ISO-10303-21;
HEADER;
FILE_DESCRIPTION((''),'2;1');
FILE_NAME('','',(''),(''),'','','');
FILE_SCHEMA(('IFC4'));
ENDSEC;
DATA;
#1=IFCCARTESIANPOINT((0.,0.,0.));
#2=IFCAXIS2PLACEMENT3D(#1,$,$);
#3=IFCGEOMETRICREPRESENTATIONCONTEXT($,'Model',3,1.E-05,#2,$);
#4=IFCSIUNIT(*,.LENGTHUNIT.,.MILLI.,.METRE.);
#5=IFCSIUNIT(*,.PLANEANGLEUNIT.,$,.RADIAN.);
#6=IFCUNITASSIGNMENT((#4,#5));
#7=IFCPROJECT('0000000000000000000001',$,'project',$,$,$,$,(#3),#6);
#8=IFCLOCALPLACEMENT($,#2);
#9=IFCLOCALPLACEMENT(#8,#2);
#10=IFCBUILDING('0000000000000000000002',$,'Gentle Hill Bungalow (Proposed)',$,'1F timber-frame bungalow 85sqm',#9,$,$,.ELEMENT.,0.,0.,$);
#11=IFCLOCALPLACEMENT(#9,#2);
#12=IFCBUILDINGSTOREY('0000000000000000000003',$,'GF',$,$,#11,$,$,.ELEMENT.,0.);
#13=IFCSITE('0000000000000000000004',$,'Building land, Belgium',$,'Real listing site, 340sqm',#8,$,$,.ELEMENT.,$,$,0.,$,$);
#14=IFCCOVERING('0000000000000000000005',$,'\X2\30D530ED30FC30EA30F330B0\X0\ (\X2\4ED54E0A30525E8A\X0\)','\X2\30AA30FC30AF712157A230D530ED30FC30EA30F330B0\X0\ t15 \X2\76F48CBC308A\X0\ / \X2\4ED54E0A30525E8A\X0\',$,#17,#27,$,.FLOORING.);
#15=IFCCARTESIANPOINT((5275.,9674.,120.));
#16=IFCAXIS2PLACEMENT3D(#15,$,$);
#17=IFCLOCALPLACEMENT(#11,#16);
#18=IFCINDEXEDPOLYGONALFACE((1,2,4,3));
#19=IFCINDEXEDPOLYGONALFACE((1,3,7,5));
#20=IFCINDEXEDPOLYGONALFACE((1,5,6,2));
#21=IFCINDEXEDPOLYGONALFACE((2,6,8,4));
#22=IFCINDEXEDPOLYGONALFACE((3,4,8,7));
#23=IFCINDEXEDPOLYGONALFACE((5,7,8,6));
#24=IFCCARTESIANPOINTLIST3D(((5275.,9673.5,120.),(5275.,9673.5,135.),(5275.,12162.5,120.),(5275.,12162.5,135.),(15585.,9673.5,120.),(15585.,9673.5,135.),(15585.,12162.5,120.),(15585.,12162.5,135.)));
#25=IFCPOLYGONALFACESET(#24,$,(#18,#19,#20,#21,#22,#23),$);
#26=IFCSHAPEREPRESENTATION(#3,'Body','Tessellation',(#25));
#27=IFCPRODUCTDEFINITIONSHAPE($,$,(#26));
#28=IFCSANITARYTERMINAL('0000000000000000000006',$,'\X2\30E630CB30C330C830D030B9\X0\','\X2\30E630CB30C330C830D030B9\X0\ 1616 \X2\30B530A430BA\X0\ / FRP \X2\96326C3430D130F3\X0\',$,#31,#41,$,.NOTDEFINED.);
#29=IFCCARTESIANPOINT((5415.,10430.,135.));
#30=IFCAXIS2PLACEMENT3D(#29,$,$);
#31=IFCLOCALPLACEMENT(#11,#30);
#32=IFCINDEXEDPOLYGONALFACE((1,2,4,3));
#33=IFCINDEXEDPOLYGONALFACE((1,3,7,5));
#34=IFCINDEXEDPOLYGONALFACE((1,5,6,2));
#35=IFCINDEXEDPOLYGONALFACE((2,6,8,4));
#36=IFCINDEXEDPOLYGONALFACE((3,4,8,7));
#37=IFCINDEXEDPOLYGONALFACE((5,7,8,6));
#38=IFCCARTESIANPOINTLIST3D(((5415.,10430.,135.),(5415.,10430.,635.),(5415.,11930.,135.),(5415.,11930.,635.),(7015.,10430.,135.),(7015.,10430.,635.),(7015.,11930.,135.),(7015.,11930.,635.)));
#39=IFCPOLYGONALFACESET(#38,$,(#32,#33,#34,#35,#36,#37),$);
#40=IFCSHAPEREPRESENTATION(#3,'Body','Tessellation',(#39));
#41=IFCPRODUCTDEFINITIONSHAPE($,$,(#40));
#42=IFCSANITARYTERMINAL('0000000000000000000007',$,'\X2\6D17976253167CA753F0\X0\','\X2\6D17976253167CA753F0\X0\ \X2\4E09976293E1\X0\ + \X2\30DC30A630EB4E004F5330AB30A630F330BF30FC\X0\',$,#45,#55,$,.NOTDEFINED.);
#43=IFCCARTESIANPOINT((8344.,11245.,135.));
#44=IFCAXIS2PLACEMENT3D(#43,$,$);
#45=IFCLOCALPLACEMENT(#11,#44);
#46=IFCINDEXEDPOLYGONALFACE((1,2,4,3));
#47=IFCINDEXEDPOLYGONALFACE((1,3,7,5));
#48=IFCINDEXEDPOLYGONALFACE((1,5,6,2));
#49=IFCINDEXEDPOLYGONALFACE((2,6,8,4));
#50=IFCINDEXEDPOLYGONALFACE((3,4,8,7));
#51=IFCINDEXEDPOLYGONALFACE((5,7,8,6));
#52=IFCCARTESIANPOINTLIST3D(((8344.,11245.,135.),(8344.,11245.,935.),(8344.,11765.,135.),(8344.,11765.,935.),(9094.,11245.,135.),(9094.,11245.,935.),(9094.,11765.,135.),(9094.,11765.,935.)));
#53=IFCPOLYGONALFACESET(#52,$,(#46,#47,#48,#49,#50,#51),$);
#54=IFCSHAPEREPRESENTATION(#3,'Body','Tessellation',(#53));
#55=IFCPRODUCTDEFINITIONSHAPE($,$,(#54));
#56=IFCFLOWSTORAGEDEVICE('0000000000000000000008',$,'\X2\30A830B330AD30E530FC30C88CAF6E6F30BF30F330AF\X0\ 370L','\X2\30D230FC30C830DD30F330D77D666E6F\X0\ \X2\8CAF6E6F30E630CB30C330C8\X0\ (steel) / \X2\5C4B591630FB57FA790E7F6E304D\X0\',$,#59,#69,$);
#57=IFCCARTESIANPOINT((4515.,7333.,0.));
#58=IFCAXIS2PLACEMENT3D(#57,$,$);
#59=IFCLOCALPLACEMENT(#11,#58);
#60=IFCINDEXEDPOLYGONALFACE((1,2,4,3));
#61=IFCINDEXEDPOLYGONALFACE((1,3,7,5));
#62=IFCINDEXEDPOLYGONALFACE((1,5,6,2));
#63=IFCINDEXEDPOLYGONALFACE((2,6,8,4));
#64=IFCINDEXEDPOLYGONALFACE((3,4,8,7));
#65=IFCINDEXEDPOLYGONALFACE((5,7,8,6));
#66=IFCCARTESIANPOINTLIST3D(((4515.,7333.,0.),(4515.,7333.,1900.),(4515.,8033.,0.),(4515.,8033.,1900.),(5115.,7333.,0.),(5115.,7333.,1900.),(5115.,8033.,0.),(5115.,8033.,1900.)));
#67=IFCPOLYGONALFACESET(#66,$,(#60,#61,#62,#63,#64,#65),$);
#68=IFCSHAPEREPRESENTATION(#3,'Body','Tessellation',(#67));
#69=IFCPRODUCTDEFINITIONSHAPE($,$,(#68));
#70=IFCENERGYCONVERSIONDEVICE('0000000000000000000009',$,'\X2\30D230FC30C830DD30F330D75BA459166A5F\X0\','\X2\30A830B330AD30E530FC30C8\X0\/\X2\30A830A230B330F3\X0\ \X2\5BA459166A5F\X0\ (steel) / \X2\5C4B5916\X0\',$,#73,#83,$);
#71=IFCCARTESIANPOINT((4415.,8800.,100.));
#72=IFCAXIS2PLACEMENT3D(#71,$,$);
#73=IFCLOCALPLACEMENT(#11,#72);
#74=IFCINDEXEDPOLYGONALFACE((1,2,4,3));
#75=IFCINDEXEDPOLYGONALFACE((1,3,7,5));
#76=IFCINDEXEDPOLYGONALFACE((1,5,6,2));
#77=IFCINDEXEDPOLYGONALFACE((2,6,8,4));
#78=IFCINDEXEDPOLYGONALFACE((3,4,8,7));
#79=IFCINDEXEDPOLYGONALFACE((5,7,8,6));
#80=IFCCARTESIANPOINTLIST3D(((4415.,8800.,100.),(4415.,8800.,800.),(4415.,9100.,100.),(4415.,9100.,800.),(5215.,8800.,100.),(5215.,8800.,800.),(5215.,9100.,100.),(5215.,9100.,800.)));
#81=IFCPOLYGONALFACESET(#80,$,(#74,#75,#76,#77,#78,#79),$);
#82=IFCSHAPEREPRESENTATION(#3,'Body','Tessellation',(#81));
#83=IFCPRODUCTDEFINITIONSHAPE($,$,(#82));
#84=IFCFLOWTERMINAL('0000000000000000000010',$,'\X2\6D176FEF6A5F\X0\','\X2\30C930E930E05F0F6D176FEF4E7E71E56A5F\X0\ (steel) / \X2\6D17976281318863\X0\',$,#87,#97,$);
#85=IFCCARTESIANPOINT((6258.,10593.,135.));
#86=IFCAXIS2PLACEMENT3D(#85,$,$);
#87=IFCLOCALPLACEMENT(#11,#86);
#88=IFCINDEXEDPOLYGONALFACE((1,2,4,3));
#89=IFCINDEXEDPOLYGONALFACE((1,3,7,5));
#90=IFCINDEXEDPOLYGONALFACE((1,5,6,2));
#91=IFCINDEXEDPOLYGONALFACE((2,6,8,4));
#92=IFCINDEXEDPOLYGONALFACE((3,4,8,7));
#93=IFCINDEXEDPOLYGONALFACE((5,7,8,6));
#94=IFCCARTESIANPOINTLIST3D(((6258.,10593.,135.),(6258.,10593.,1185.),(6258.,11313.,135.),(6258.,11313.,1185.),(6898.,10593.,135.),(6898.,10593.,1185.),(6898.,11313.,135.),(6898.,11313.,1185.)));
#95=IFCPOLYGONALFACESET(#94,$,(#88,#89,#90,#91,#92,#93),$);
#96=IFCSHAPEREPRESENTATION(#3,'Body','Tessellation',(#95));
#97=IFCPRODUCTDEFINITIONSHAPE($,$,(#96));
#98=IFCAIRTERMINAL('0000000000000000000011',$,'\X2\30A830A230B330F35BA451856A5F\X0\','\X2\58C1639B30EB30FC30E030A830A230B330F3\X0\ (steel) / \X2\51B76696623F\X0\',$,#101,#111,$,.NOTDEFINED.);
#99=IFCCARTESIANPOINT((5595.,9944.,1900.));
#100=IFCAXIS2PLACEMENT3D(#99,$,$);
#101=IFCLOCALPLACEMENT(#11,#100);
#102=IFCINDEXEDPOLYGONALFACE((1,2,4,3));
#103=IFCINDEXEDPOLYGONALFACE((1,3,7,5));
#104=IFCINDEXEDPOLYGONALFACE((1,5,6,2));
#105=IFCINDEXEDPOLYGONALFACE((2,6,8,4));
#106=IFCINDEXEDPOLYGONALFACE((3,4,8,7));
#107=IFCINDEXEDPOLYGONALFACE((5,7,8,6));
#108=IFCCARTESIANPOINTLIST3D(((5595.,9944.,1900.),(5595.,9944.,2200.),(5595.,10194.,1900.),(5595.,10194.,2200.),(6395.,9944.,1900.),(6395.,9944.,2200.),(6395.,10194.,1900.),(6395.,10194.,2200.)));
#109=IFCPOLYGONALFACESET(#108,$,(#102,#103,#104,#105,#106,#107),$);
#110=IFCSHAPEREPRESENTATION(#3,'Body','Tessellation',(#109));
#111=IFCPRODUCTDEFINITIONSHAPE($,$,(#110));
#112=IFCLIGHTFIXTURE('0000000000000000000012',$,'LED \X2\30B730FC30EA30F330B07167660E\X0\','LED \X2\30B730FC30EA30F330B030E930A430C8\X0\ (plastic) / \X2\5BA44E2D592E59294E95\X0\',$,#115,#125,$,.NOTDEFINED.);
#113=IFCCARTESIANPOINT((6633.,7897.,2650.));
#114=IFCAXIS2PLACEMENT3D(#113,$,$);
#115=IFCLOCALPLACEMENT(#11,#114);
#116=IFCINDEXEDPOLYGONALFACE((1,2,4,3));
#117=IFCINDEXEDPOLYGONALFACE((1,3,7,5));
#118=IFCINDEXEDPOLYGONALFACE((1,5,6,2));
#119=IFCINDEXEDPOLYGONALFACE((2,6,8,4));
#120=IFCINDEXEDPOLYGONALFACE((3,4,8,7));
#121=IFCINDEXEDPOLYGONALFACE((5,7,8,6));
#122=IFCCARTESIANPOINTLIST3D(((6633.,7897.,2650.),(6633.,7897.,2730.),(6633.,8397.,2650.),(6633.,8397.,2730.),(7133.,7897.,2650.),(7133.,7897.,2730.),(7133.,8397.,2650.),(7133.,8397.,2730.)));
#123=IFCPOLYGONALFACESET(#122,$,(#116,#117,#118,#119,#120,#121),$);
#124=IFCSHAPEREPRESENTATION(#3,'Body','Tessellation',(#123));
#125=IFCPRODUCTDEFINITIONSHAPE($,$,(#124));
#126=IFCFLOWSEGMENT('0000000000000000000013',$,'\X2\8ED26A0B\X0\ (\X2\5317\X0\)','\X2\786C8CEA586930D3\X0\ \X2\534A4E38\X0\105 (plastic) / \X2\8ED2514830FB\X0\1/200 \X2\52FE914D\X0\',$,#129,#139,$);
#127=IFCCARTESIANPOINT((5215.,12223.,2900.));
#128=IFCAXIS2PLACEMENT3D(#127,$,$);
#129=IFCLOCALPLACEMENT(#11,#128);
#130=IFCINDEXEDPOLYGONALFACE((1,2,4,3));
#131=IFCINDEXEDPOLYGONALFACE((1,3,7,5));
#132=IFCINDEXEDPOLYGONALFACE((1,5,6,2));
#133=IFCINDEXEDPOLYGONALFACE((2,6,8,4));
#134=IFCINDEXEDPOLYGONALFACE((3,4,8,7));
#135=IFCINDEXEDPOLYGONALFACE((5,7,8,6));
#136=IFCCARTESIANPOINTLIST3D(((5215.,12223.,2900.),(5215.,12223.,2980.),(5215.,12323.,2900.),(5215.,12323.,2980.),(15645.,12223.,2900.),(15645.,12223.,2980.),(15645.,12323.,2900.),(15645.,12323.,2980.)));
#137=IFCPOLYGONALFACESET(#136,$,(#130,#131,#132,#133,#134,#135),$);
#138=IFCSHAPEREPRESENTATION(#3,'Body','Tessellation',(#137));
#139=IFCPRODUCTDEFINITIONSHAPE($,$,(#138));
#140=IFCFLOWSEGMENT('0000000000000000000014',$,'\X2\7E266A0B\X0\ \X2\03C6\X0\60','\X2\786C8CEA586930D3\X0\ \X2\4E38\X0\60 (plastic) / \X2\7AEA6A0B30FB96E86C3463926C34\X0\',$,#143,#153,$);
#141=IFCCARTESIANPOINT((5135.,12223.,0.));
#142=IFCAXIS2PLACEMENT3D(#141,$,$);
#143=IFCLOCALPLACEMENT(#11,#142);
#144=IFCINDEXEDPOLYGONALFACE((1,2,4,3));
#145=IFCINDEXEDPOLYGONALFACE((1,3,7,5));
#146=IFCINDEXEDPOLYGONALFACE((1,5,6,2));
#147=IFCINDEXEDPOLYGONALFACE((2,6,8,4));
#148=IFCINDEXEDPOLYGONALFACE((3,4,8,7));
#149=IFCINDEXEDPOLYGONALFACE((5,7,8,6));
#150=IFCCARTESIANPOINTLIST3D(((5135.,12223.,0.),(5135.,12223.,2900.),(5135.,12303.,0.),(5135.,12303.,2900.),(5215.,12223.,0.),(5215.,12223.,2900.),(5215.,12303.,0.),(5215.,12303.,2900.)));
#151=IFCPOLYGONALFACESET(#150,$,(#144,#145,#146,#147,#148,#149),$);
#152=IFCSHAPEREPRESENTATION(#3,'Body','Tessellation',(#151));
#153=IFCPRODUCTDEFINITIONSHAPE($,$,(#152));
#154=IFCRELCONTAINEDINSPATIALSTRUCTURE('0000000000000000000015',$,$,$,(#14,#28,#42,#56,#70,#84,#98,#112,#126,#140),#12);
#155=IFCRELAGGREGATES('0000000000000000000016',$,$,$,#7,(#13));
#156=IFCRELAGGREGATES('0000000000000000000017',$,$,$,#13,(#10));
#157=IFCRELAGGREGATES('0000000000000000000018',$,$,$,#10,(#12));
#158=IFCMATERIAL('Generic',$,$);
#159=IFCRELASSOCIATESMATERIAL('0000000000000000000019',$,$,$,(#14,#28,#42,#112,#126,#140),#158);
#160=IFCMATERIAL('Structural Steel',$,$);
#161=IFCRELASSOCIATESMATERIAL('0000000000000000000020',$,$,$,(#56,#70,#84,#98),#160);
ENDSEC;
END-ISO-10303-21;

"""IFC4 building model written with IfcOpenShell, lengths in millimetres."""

from ifc_helpers import new_model, si_unit, frame, frame_2d, origin, place, context, project, spatial, rectangle, extrude, material, element, save


model = new_model("IFC4")

# Units and contexts
model_context = context("Model", 3, precision=1e-05, world=origin())
ifc_project = project(units=[si_unit("LENGTHUNIT", "METRE", prefix="MILLI"), si_unit("PLANEANGLEUNIT", "RADIAN")], contexts=[model_context])

# Site, building, storey
site_placement = place(None, origin())
site = spatial("IfcSite", under=ifc_project, at=site_placement, Name="Building land, Belgium", ObjectType="Real listing site, 340sqm", CompositionType="ELEMENT", RefElevation=0.0)
building_placement = place(site_placement, origin())
building = spatial("IfcBuilding", under=site, at=building_placement, Name="Gentle Hill Bungalow (Proposed)", ObjectType="1F timber-frame bungalow 85sqm", CompositionType="ELEMENT", ElevationOfRefHeight=0.0, ElevationOfTerrain=0.0)
storey_placement = place(building_placement, origin())
storey = spatial("IfcBuildingStorey", under=building, at=storey_placement, Name="GF", CompositionType="ELEMENT", Elevation=0.0)

# Shared definitions
ifc_material_1 = material(Name="Structural Steel")

# Covering
ifc_material_2 = material(Name="Generic")
covering_1_placement = place(storey_placement, frame((5275.0, 9674.0, 120.0)))
element("IfcCovering", 1, at=covering_1_placement, inside=storey, material=ifc_material_2, Name="フローリング (仕上げ床)", Description="オーク無垢フローリング t15 直貼り / 仕上げ床", PredefinedType="FLOORING", context=model_context, shape_type="SweptSolid", body=[
    extrude(rectangle(XDim=10310.0, YDim=2489.0, at=frame_2d((5155.0, 1244.0))), frame((5275.0, 9674.0, 120.0)), (0.0, 0.0, 1.0), 15.0),
])

# Sanitary terminals
sanitary_terminal_1_placement = place(storey_placement, frame((5415.0, 10430.0, 135.0)))
element("IfcSanitaryTerminal", 2, at=sanitary_terminal_1_placement, inside=storey, material=ifc_material_2, Name="ユニットバス", Description="ユニットバス 1616 サイズ / FRP 防水パン", PredefinedType="NOTDEFINED", context=model_context, shape_type="SweptSolid", body=[
    extrude(rectangle(XDim=1600.0, YDim=1500.0, at=frame_2d((800.0, 750.0))), frame((5415.0, 10430.0, 135.0)), (0.0, 0.0, 1.0), 500.0),
])
sanitary_terminal_2_placement = place(storey_placement, frame((8344.0, 11245.0, 135.0)))
element("IfcSanitaryTerminal", 3, at=sanitary_terminal_2_placement, inside=storey, material=ifc_material_2, Name="洗面化粧台", Description="洗面化粧台 三面鏡 + ボウル一体カウンター", PredefinedType="NOTDEFINED", context=model_context, shape_type="SweptSolid", body=[
    extrude(rectangle(XDim=750.0, YDim=520.0, at=frame_2d((375.0, 260.0))), frame((8344.0, 11245.0, 135.0)), (0.0, 0.0, 1.0), 800.0),
])

# Flow storage device
flow_storage_device_placement = place(storey_placement, frame((4515.0, 7333.0, 0.0)))
element("IfcFlowStorageDevice", 4, at=flow_storage_device_placement, inside=storey, material=ifc_material_1, Name="エコキュート貯湯タンク 370L", Description="ヒートポンプ給湯 貯湯ユニット (steel) / 屋外・基礎置き", context=model_context, shape_type="SweptSolid", body=[
    extrude(rectangle(XDim=600.0, YDim=700.0, at=frame_2d((300.0, 350.0))), frame((4515.0, 7333.0, 0.0)), (0.0, 0.0, 1.0), 1900.0),
])

# Energy conversion device
energy_conversion_device_placement = place(storey_placement, frame((4415.0, 8800.0, 100.0)))
element("IfcEnergyConversionDevice", 5, at=energy_conversion_device_placement, inside=storey, material=ifc_material_1, Name="ヒートポンプ室外機", Description="エコキュート/エアコン 室外機 (steel) / 屋外", context=model_context, shape_type="SweptSolid", body=[
    extrude(rectangle(XDim=800.0, YDim=300.0, at=frame_2d((400.0, 150.0))), frame((4415.0, 8800.0, 100.0)), (0.0, 0.0, 1.0), 700.0),
])

# Flow terminal
flow_terminal_placement = place(storey_placement, frame((6258.0, 10593.0, 135.0)))
element("IfcFlowTerminal", 6, at=flow_terminal_placement, inside=storey, material=ifc_material_1, Name="洗濯機", Description="ドラム式洗濯乾燥機 (steel) / 洗面脱衣", context=model_context, shape_type="SweptSolid", body=[
    extrude(rectangle(XDim=640.0, YDim=720.0, at=frame_2d((320.0, 360.0))), frame((6258.0, 10593.0, 135.0)), (0.0, 0.0, 1.0), 1050.0),
])

# Air terminal
air_terminal_placement = place(storey_placement, frame((5595.0, 9944.0, 1900.0)))
element("IfcAirTerminal", 7, at=air_terminal_placement, inside=storey, material=ifc_material_1, Name="エアコン室内機", Description="壁掛ルームエアコン (steel) / 冷暖房", PredefinedType="NOTDEFINED", context=model_context, shape_type="SweptSolid", body=[
    extrude(rectangle(XDim=800.0, YDim=250.0, at=frame_2d((400.0, 125.0))), frame((5595.0, 9944.0, 1900.0)), (0.0, 0.0, 1.0), 300.0),
])

# Light fixture
light_fixture_placement = place(storey_placement, frame((6633.0, 7897.0, 2650.0)))
element("IfcLightFixture", 8, at=light_fixture_placement, inside=storey, material=ifc_material_2, Name="LED シーリング照明", Description="LED シーリングライト (plastic) / 室中央天井", PredefinedType="NOTDEFINED", context=model_context, shape_type="SweptSolid", body=[
    extrude(rectangle(XDim=500.0, YDim=500.0, at=frame_2d((250.0, 250.0))), frame((6633.0, 7897.0, 2650.0)), (0.0, 0.0, 1.0), 80.0),
])

# Flow segments
flow_segment_1_placement = place(storey_placement, frame((5215.0, 12223.0, 2900.0)))
element("IfcFlowSegment", 9, at=flow_segment_1_placement, inside=storey, material=ifc_material_2, Name="軒樋 (北)", Description="硬質塩ビ 半丸105 (plastic) / 軒先・1/200 勾配", context=model_context, shape_type="SweptSolid", body=[
    extrude(rectangle(XDim=10430.0, YDim=100.0, at=frame_2d((5215.0, 50.0))), frame((5215.0, 12223.0, 2900.0)), (0.0, 0.0, 1.0), 80.0),
])
flow_segment_2_placement = place(storey_placement, frame((5135.0, 12223.0, 0.0)))
element("IfcFlowSegment", 10, at=flow_segment_2_placement, inside=storey, material=ifc_material_2, Name="縦樋 φ60", Description="硬質塩ビ 丸60 (plastic) / 竪樋・雨水排水", context=model_context, shape_type="SweptSolid", body=[
    extrude(rectangle(XDim=80.0, YDim=80.0, at=frame_2d((40.0, 40.0))), frame((5135.0, 12223.0, 0.0)), (0.0, 0.0, 1.0), 2900.0),
])

save(model, "model.ifc")
